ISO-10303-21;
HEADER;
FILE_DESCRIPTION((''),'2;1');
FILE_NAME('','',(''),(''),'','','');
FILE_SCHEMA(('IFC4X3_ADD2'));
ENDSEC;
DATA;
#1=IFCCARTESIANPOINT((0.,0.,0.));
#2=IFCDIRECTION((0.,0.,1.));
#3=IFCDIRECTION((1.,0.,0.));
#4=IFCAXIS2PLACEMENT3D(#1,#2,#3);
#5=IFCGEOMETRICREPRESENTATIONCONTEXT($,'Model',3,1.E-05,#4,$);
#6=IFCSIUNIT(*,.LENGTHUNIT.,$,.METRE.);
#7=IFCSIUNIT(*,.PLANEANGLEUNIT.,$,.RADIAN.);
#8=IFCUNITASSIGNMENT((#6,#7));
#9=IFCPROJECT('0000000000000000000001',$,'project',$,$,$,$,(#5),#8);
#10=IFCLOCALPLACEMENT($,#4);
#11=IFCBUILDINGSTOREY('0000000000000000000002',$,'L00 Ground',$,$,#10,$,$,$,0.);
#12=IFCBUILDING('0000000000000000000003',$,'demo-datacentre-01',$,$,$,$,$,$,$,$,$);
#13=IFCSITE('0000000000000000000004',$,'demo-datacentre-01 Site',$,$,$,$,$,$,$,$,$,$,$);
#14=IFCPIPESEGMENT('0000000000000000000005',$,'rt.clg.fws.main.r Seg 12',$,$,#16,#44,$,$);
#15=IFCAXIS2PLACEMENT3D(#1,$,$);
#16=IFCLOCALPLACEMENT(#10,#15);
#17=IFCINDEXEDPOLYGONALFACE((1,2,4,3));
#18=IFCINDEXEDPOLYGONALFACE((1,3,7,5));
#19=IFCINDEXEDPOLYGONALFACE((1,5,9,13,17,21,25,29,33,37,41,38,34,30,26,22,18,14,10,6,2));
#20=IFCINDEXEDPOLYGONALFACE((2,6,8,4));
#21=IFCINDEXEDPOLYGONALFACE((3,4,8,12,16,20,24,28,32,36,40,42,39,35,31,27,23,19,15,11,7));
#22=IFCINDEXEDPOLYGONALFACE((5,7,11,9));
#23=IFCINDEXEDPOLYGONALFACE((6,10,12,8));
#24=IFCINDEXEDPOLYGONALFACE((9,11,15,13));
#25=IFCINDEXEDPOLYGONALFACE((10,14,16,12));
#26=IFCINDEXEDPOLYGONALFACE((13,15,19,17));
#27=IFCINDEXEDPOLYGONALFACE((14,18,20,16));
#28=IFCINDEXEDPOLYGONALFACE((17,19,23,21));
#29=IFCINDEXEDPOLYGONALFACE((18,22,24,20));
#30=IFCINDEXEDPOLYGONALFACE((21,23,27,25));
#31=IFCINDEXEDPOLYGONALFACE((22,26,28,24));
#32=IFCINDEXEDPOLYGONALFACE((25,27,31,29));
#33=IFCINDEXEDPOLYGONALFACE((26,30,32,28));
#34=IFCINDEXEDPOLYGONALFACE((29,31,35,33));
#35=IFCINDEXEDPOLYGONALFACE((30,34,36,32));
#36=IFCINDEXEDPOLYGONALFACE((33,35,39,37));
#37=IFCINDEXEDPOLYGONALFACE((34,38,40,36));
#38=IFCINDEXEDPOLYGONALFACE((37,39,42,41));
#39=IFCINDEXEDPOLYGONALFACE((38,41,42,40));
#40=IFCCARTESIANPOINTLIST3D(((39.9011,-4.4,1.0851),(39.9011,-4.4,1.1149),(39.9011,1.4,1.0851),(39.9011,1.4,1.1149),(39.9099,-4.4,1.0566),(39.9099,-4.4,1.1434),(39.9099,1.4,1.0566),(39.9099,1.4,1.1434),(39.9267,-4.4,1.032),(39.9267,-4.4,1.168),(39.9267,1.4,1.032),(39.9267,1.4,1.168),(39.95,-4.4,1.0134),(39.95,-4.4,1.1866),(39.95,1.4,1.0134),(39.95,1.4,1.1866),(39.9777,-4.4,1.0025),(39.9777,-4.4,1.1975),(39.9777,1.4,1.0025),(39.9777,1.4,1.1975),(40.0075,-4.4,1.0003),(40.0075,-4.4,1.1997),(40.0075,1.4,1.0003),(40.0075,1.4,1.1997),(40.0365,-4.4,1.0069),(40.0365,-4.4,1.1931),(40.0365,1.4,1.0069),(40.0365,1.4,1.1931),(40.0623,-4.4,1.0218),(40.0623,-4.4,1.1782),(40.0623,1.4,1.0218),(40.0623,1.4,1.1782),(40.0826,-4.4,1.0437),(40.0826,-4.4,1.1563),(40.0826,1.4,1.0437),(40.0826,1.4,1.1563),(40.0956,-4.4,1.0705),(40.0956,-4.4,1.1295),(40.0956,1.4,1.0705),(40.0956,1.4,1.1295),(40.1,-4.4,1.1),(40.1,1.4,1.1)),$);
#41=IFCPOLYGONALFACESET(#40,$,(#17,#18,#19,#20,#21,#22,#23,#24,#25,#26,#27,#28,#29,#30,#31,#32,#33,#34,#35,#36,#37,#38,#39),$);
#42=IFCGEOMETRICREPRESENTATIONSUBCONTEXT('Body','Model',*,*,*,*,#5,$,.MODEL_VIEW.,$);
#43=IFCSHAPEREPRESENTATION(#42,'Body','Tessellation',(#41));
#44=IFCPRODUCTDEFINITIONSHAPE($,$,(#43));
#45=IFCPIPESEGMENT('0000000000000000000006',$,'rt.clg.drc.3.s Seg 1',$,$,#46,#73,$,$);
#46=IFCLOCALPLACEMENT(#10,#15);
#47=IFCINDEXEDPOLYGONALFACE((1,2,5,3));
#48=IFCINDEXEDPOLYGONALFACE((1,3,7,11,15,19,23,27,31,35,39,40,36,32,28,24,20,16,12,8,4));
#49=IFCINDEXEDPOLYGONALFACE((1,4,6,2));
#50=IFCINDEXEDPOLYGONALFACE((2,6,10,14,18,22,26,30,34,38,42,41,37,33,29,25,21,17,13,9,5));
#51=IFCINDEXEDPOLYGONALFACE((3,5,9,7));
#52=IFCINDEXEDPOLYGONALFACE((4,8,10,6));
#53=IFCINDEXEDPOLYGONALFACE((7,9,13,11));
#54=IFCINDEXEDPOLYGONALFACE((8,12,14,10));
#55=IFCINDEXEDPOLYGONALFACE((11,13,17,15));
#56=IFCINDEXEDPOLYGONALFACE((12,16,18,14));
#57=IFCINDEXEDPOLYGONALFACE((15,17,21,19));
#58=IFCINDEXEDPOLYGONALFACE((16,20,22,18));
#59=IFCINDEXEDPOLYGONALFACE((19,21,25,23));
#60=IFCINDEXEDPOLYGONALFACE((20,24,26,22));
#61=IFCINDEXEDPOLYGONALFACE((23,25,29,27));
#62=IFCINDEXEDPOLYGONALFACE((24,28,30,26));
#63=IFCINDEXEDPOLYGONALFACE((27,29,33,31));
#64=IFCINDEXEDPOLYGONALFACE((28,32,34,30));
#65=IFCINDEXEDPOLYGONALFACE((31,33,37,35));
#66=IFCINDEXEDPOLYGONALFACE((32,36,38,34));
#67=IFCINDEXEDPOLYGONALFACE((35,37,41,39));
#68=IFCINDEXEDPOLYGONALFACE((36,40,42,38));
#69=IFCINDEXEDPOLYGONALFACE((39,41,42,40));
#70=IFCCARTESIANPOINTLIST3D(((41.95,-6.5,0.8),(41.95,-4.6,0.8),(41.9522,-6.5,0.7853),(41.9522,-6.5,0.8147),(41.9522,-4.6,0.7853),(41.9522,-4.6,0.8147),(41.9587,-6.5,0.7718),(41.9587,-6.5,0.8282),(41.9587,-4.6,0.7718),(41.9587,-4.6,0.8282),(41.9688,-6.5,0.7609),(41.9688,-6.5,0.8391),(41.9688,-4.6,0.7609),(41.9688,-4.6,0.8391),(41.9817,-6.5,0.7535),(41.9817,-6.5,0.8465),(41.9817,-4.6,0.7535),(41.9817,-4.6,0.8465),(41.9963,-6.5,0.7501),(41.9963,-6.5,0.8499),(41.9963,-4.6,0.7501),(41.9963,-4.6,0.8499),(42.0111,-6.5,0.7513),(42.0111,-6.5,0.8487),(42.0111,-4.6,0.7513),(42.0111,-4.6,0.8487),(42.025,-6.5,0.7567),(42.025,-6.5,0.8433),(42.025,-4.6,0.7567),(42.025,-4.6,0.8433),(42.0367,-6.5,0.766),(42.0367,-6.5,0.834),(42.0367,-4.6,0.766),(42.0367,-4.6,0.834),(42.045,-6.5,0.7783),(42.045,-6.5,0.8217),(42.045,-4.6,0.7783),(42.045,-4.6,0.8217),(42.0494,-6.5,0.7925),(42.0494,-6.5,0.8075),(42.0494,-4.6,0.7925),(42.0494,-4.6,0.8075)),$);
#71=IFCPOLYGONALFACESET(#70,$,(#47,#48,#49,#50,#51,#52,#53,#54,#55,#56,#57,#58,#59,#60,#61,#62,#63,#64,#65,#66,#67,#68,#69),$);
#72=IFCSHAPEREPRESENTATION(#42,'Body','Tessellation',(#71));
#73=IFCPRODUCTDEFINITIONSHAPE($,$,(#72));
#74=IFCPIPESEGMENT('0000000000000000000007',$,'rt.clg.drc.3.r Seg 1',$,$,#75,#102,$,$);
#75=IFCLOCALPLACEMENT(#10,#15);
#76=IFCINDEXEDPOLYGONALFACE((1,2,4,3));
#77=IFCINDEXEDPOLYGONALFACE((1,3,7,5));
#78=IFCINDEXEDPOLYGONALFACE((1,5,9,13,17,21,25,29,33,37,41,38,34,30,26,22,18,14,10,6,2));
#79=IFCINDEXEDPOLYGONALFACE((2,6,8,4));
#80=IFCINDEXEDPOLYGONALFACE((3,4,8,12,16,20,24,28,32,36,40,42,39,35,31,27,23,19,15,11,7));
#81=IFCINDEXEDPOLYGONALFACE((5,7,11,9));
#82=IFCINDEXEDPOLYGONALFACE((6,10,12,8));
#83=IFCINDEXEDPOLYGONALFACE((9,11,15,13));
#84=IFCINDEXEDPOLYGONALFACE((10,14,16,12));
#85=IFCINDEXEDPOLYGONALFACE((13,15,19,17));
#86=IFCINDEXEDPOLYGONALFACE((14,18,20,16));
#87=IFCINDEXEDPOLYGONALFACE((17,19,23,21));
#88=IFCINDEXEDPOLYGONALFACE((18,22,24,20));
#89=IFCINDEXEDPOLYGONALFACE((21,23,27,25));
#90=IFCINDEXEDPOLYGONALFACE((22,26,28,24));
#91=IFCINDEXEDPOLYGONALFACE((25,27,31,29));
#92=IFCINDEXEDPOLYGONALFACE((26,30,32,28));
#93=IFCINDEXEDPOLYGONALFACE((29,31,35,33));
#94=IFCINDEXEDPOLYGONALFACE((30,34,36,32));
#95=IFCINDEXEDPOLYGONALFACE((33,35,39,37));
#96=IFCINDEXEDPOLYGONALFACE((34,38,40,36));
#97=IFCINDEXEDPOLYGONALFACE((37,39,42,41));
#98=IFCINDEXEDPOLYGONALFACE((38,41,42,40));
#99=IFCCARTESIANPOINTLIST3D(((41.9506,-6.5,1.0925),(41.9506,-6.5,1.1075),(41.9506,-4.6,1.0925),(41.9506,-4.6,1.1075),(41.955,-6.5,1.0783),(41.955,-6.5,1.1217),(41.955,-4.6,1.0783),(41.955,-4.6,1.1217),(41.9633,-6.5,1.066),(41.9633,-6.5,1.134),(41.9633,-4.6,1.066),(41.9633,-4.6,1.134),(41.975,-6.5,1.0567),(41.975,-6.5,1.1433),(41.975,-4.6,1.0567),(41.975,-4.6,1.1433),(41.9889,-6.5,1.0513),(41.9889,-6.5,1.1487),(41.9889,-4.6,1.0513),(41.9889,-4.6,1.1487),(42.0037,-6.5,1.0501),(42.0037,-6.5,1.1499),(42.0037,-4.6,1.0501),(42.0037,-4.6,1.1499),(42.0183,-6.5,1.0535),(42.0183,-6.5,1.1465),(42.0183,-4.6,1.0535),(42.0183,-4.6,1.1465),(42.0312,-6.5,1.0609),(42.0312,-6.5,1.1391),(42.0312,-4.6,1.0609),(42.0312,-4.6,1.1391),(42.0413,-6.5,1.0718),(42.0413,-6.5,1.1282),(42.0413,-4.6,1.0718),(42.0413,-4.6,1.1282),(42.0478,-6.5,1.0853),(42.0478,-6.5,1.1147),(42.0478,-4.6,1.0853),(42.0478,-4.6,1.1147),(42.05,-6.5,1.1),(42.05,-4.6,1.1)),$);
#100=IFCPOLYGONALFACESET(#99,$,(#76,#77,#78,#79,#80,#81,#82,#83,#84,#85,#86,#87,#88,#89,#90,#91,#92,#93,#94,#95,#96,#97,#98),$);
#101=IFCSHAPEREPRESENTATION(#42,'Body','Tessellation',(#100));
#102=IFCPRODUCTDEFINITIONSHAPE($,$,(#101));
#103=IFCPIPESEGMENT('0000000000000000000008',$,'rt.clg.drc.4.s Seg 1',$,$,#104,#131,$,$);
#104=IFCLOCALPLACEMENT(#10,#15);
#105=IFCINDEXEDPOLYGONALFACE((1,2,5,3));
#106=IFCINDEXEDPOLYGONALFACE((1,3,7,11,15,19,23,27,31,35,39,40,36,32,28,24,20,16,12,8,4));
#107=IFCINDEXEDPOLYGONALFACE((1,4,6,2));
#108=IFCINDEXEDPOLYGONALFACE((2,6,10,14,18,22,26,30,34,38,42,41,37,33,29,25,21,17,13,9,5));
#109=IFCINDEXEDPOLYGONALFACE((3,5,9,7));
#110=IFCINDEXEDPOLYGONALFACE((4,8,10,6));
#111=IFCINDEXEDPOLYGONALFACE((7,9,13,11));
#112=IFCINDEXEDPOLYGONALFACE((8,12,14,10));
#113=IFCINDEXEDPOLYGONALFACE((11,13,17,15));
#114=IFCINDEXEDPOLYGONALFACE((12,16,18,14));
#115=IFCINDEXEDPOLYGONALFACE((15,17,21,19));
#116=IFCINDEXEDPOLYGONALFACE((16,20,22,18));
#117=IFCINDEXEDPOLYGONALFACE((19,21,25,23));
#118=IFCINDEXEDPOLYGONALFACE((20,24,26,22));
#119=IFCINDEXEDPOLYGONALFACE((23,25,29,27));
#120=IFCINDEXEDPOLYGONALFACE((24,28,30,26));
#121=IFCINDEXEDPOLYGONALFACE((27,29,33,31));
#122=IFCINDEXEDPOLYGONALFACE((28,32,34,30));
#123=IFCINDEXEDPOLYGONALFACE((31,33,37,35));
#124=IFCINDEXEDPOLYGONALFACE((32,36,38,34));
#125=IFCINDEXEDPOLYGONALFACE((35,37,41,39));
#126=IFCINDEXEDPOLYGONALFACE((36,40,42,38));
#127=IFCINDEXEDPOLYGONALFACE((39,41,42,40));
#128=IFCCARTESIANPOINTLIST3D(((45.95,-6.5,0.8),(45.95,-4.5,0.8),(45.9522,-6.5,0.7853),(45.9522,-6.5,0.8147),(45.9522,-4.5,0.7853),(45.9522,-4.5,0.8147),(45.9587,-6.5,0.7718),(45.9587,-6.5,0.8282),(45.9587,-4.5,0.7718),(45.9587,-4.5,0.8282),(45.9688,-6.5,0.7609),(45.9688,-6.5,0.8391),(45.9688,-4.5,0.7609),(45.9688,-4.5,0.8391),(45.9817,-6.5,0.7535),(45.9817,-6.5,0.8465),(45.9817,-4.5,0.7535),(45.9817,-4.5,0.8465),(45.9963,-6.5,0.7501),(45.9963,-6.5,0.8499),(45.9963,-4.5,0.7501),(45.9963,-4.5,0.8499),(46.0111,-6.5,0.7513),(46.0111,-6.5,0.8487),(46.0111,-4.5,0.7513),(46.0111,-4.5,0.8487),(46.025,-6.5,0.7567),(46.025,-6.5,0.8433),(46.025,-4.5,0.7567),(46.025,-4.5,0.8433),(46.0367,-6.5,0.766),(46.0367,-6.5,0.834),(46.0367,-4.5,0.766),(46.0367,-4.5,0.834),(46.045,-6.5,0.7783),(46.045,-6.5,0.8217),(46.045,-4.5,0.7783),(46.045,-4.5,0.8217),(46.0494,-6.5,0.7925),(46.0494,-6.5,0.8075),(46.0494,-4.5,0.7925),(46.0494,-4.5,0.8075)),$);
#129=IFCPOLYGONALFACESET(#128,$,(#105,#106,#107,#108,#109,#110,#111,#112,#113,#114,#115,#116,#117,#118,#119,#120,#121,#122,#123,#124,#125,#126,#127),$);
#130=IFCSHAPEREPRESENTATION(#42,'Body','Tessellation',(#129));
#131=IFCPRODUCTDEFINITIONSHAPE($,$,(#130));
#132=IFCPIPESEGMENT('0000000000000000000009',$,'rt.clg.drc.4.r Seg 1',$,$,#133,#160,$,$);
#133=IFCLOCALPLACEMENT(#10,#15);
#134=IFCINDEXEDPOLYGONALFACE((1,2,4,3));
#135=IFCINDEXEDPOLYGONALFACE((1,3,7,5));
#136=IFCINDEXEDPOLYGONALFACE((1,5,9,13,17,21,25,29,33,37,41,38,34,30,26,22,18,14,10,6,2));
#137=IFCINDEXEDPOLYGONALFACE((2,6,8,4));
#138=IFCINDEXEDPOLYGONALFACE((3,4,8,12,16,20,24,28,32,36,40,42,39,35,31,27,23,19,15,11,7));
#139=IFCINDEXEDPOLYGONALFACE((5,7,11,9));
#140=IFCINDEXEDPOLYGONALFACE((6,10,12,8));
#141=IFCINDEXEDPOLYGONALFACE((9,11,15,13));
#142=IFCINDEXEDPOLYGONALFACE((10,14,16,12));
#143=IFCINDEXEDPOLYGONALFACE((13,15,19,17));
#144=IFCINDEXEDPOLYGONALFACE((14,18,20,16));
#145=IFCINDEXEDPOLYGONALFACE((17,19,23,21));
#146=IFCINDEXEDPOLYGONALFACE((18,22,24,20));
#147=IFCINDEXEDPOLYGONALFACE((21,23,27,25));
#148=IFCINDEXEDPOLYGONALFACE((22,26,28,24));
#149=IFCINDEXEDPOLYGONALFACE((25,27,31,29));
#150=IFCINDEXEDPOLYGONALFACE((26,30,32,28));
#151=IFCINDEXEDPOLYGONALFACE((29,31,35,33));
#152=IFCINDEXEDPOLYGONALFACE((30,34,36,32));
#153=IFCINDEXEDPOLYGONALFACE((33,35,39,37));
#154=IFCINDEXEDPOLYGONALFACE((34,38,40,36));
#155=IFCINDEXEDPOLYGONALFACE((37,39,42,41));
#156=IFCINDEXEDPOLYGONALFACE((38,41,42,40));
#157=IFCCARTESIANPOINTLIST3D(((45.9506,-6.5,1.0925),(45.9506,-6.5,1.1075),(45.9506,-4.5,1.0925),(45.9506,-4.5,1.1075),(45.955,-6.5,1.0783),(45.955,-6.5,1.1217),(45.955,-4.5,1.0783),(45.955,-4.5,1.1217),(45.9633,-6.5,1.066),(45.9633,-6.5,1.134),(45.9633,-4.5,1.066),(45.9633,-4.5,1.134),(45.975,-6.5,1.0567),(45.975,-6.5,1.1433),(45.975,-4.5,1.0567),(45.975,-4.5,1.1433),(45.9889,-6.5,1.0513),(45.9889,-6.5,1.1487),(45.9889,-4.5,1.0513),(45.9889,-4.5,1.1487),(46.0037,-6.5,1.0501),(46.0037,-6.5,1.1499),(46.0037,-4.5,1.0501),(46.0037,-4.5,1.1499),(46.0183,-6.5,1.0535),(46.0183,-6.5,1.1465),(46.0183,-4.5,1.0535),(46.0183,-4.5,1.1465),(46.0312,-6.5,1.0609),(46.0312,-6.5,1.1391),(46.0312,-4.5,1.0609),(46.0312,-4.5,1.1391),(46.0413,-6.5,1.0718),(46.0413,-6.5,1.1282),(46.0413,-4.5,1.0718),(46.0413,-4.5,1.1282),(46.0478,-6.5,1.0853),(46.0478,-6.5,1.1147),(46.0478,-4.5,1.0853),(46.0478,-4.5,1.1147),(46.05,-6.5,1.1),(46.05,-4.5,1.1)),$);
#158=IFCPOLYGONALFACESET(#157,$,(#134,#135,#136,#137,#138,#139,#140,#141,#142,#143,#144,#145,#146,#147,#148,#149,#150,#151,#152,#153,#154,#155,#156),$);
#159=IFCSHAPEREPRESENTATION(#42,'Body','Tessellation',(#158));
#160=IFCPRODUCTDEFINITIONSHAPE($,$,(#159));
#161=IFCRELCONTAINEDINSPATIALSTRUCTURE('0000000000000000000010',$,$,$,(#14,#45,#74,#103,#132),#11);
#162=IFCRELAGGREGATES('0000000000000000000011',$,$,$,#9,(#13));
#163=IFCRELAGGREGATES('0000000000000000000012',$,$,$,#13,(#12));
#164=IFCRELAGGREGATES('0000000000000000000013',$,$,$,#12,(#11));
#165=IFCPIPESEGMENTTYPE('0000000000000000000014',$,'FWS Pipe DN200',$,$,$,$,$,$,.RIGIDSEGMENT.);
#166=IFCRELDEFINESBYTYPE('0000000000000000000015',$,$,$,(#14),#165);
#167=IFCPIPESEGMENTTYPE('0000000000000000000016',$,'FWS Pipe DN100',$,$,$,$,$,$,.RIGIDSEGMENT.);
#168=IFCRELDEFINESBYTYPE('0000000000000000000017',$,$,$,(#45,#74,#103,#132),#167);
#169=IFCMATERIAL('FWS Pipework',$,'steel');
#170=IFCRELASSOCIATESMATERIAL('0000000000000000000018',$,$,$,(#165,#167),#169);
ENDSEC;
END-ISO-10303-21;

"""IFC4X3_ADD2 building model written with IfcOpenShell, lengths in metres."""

from ifc_helpers import new_model, si_unit, frame, origin_with_axes, place, context, subcontext, project, spatial, circle, extrude, material, type_object, element, save


model = new_model("IFC4X3_ADD2")

# Units and contexts
model_context = context("Model", 3, precision=1e-05, world=origin_with_axes())
body_context = subcontext(model_context, "Body", "Model", "MODEL_VIEW")
ifc_project = project(units=[si_unit("LENGTHUNIT", "METRE"), si_unit("PLANEANGLEUNIT", "RADIAN")], contexts=[model_context])

# Site, building, storey
site = spatial("IfcSite", under=ifc_project, Name="demo-datacentre-01 Site")
building = spatial("IfcBuilding", under=site, Name="demo-datacentre-01")
storey_placement = place(None, origin_with_axes())
storey = spatial("IfcBuildingStorey", under=building, at=storey_placement, Name="L00 Ground", Elevation=0.0)

# Shared definitions
ifc_material = material(Name="FWS Pipework", Category="steel")

# Pipe segments
pipe_segment_type_1 = type_object("IfcPipeSegmentType", Name="FWS Pipe DN200", PredefinedType="RIGIDSEGMENT", material=ifc_material)
pipe_segment_1_placement = place(storey_placement, frame((40.0, 1.4, 1.1), z_axis=(0.0, -1.0, 0.0), x_axis=(1.0, 0.0, 0.0)))
element("IfcPipeSegment", 1, at=pipe_segment_1_placement, inside=storey, type_object=pipe_segment_type_1, Name="rt.clg.fws.main.r Seg 12", context=body_context, shape_type="SweptSolid", body=[
    extrude(circle(Radius=0.1), origin_with_axes(), (0.0, 0.0, 1.0), 5.8),
])
pipe_segment_type_2 = type_object("IfcPipeSegmentType", Name="FWS Pipe DN100", PredefinedType="RIGIDSEGMENT", material=ifc_material)
for number, where, z_axis, x_axis, name in (
    (2, (42.0, -6.5, 0.8), (0.0, 1.0, 0.0), (-1.0, 0.0, 0.0), "rt.clg.drc.3.s Seg 1"),
    (3, (42.0, -4.6, 1.1), (0.0, -1.0, 0.0), (1.0, 0.0, 0.0), "rt.clg.drc.3.r Seg 1"),
):
    element("IfcPipeSegment", number, at=place(storey_placement, frame(where, z_axis=z_axis, x_axis=x_axis)), inside=storey, type_object=pipe_segment_type_2, Name=name, context=body_context, shape_type="SweptSolid", body=[
        extrude(circle(Radius=0.05), origin_with_axes(), (0.0, 0.0, 1.0), 1.9),
    ])
for number, where, z_axis, x_axis, name in (
    (4, (46.0, -6.5, 0.8), (0.0, 1.0, 0.0), (-1.0, 0.0, 0.0), "rt.clg.drc.4.s Seg 1"),
    (5, (46.0, -4.5, 1.1), (0.0, -1.0, 0.0), (1.0, 0.0, 0.0), "rt.clg.drc.4.r Seg 1"),
):
    element("IfcPipeSegment", number, at=place(storey_placement, frame(where, z_axis=z_axis, x_axis=x_axis)), inside=storey, type_object=pipe_segment_type_2, Name=name, context=body_context, shape_type="SweptSolid", body=[
        extrude(circle(Radius=0.05), origin_with_axes(), (0.0, 0.0, 1.0), 2.0),
    ])

save(model, "model.ifc")
